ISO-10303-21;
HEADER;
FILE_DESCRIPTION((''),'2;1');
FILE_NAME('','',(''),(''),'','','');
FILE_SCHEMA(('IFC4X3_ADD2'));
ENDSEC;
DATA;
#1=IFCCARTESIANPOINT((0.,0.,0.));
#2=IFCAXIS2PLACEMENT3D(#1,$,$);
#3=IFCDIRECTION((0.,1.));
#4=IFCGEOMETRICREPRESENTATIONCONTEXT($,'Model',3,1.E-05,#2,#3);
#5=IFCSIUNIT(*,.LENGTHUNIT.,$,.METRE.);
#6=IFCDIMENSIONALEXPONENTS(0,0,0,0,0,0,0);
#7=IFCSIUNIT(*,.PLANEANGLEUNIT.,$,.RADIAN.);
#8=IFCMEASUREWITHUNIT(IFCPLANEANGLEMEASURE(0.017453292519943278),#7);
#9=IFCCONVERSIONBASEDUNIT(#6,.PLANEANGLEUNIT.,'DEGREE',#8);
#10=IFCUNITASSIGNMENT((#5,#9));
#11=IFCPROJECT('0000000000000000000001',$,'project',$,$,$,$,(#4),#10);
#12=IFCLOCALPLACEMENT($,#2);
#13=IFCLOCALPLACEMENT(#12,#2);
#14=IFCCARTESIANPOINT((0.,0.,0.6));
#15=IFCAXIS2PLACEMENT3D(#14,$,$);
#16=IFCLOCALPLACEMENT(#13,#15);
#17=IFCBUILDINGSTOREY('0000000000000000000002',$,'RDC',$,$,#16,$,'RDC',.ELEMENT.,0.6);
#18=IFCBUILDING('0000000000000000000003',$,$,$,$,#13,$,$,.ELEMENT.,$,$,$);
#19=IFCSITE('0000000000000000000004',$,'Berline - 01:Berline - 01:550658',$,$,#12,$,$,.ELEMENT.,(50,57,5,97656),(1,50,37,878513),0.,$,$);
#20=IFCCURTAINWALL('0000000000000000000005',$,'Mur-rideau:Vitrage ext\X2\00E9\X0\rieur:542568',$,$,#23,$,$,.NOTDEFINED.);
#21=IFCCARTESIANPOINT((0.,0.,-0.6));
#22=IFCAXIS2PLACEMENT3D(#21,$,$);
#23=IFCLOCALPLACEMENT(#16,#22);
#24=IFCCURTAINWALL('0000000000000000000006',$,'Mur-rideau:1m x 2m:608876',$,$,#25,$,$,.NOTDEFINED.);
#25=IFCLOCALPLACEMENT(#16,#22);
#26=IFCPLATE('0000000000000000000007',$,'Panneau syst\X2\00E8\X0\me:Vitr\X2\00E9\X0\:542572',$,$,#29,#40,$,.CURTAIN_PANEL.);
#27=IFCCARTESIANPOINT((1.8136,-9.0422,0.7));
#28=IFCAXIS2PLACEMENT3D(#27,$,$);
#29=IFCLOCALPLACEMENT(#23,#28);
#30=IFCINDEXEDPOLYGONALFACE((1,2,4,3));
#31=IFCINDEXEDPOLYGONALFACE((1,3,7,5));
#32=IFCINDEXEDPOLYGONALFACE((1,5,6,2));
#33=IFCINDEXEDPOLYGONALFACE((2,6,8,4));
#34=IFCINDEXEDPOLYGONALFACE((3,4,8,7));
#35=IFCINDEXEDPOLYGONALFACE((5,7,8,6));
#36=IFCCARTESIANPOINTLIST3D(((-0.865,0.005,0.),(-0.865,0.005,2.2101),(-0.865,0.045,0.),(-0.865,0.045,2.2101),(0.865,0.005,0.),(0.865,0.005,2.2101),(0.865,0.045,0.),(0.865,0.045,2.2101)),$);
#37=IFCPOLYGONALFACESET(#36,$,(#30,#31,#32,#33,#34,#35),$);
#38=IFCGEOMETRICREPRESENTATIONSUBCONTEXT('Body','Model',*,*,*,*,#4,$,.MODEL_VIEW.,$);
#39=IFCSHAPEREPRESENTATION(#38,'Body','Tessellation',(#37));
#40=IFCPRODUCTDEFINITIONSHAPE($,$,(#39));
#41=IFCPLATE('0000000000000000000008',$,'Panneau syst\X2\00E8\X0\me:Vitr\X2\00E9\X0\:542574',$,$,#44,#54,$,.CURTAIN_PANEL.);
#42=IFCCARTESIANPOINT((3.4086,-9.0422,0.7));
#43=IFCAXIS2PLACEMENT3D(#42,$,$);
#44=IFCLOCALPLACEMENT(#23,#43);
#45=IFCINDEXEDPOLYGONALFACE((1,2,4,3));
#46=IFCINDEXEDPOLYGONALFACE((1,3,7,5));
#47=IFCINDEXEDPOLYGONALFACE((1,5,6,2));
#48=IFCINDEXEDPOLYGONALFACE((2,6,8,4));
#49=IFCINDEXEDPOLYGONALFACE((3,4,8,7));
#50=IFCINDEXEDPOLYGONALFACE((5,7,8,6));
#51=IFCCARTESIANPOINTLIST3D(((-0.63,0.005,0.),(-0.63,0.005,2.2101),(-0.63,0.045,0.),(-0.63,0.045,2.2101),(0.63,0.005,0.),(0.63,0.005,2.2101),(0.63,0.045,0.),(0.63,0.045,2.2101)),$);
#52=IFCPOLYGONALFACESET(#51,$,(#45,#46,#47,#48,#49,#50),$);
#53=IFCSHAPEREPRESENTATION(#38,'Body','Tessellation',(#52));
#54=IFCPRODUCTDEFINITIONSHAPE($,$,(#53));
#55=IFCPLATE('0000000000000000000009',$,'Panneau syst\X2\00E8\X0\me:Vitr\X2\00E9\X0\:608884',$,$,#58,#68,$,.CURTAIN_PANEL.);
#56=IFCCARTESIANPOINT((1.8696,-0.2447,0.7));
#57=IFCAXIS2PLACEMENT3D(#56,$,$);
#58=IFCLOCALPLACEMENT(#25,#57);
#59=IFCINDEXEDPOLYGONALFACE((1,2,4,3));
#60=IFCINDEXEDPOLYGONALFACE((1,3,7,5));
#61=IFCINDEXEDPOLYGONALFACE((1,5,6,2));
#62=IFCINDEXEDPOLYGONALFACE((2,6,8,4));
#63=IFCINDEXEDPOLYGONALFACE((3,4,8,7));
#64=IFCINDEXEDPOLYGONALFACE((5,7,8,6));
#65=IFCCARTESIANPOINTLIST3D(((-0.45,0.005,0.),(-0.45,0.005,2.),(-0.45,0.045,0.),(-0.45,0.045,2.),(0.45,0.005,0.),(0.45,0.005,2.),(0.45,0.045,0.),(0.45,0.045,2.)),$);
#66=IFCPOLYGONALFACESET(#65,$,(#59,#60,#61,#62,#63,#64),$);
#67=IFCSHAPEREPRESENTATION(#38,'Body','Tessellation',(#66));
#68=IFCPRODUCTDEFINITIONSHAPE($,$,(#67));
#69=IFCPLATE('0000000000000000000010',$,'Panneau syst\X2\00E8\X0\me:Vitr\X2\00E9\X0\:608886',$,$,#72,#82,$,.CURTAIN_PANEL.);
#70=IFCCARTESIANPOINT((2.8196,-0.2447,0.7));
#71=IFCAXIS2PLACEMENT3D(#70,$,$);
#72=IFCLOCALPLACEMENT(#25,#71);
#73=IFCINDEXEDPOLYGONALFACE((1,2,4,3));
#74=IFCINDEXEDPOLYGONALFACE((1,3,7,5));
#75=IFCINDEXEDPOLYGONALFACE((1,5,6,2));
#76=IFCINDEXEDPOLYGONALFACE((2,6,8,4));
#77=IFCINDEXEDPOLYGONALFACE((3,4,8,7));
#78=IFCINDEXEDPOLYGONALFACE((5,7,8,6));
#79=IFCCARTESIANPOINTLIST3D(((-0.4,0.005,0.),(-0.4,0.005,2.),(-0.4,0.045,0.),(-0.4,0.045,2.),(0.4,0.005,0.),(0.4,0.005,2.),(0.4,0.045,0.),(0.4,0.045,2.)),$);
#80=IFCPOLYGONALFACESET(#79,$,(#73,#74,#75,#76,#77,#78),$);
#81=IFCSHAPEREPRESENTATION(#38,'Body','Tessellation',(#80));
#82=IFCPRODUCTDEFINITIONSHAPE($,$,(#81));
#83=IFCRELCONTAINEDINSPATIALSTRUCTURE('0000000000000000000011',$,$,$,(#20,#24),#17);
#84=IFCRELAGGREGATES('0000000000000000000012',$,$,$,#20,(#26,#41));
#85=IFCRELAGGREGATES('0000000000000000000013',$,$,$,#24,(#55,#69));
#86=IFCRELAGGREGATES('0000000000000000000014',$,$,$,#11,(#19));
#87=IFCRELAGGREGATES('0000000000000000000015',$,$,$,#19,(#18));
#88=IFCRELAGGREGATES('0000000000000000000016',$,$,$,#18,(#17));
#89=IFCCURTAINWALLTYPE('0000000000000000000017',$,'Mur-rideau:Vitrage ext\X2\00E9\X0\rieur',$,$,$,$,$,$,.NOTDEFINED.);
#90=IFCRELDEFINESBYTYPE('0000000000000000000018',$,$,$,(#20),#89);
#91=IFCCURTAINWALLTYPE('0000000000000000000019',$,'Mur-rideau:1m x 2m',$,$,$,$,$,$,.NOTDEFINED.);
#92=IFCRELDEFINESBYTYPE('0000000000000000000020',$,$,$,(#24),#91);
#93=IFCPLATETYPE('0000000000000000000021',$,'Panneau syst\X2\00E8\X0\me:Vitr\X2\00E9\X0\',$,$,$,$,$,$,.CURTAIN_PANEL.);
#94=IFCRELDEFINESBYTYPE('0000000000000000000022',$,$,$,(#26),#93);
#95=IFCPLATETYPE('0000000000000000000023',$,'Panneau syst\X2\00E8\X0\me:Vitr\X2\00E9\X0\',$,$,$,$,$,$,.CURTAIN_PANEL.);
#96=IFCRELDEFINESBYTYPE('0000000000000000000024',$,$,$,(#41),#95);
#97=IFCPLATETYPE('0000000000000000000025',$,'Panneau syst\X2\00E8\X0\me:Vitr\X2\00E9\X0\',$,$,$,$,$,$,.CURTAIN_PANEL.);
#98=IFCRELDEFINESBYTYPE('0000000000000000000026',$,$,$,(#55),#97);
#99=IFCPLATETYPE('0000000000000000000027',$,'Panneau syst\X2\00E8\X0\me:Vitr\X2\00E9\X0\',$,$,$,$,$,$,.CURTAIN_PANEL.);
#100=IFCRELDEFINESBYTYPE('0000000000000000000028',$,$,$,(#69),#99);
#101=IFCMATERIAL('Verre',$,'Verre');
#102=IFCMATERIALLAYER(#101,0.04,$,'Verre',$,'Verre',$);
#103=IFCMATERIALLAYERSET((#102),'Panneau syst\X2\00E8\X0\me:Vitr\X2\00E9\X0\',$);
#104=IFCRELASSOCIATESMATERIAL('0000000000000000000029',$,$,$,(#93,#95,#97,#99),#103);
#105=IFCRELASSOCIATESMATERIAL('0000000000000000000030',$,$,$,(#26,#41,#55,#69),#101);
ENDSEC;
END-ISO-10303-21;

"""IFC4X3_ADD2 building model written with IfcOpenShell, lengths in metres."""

from ifc_helpers import new_model, entity, si_unit, converted_unit, direction, frame, frame_2d, origin, place, context, subcontext, project, spatial, rectangle, extrude, source, transform, mapped, material, layer, layer_set, type_object, type_shapes, element, aggregate, save


model = new_model("IFC4X3_ADD2")

# Units and contexts
model_context = context("Model", 3, precision=1e-05, world=origin(), true_north=direction((0.0, 1.0)))
body_context = subcontext(model_context, "Body", "Model", "MODEL_VIEW")
ifc_project = project(units=[si_unit("LENGTHUNIT", "METRE"), converted_unit("PLANEANGLEUNIT", "DEGREE", entity("IfcPlaneAngleMeasure", 0.017453292519943278), si_unit("PLANEANGLEUNIT", "RADIAN"), dimensions=[0, 0, 0, 0, 0, 0, 0])], contexts=[model_context])

# Site, building, storey
site_placement = place(None, origin())
site = spatial("IfcSite", under=ifc_project, at=site_placement, Name="Berline - 01:Berline - 01:550658", CompositionType="ELEMENT", RefLatitude=(50, 57, 5, 97656), RefLongitude=(1, 50, 37, 878513), RefElevation=0.0)
building_placement = place(site_placement, origin())
building = spatial("IfcBuilding", under=site, at=building_placement, CompositionType="ELEMENT")
storey_placement = place(building_placement, frame((0.0, 0.0, 0.6)))
storey = spatial("IfcBuildingStorey", under=building, at=storey_placement, Name="RDC", LongName="RDC", CompositionType="ELEMENT", Elevation=0.6)

# Curtain walls
curtain_wall_type_1 = type_object("IfcCurtainWallType", Name="Mur-rideau:Vitrage extérieur", PredefinedType="NOTDEFINED")
curtain_wall_1_placement = place(storey_placement, frame((0.0, 0.0, -0.6)))
curtain_wall_1 = element("IfcCurtainWall", 1, at=curtain_wall_1_placement, inside=storey, type_object=curtain_wall_type_1, Name="Mur-rideau:Vitrage extérieur:542568", PredefinedType="NOTDEFINED")
curtain_wall_type_2 = type_object("IfcCurtainWallType", Name="Mur-rideau:1m x 2m", PredefinedType="NOTDEFINED")
curtain_wall_2_placement = place(storey_placement, frame((0.0, 0.0, -0.6)))
curtain_wall_2 = element("IfcCurtainWall", 2, at=curtain_wall_2_placement, inside=storey, type_object=curtain_wall_type_2, Name="Mur-rideau:1m x 2m:608876", PredefinedType="NOTDEFINED")

# Plates
ifc_material_1 = material(Name="Verre", Category="Verre")
ifc_layer_1 = layer(ifc_material_1, 0.04, Name="Verre", Category="Verre")
ifc_layer_set_1 = layer_set([ifc_layer_1], Name="Panneau système:Vitré")
plate_type_1 = type_object("IfcPlateType", Name="Panneau système:Vitré", PredefinedType="CURTAIN_PANEL", material=ifc_layer_set_1)
shared_shape_1 = source(origin(), body_context, "Body", "SweptSolid", [
    extrude(rectangle(XDim=0.04, YDim=1.73, at=frame_2d((0.0, 0.0), x_axis=(1.0, 0.0))), frame((0.0, 0.025, 0.0), z_axis=(0.0, 0.0, 1.0), x_axis=(0.0, 1.0, 0.0)), (0.0, 0.0, 1.0), 2.2101),
])
type_shapes(plate_type_1, [shared_shape_1])
plate_1_placement = place(curtain_wall_1_placement, frame((1.8136, -9.0422, 0.7)))
plate_1 = element("IfcPlate", 3, at=plate_1_placement, type_object=plate_type_1, material=ifc_material_1, Name="Panneau système:Vitré:542572", PredefinedType="CURTAIN_PANEL", context=body_context, shape_type="MappedRepresentation", body=[
    mapped(shared_shape_1, transform((0.0, 0.0, 0.0), scale=1.0)),
])
plate_type_2 = type_object("IfcPlateType", Name="Panneau système:Vitré", PredefinedType="CURTAIN_PANEL", material=ifc_layer_set_1)
shared_shape_2 = source(origin(), body_context, "Body", "SweptSolid", [
    extrude(rectangle(XDim=0.04, YDim=1.26, at=frame_2d((0.0, 0.0), x_axis=(1.0, 0.0))), frame((0.0, 0.025, 0.0), z_axis=(0.0, 0.0, 1.0), x_axis=(0.0, 1.0, 0.0)), (0.0, 0.0, 1.0), 2.2101),
])
type_shapes(plate_type_2, [shared_shape_2])
plate_2_placement = place(curtain_wall_1_placement, frame((3.4086, -9.0422, 0.7)))
plate_2 = element("IfcPlate", 4, at=plate_2_placement, type_object=plate_type_2, material=ifc_material_1, Name="Panneau système:Vitré:542574", PredefinedType="CURTAIN_PANEL", context=body_context, shape_type="MappedRepresentation", body=[
    mapped(shared_shape_2, transform((0.0, 0.0, 0.0), scale=1.0)),
])
aggregate(curtain_wall_1, [plate_1, plate_2])
plate_type_3 = type_object("IfcPlateType", Name="Panneau système:Vitré", PredefinedType="CURTAIN_PANEL", material=ifc_layer_set_1)
shared_shape_3 = source(origin(), body_context, "Body", "SweptSolid", [
    extrude(rectangle(XDim=0.04, YDim=0.9, at=frame_2d((0.0, 0.0), x_axis=(1.0, 0.0))), frame((0.0, 0.025, 0.0), z_axis=(0.0, 0.0, 1.0), x_axis=(0.0, 1.0, 0.0)), (0.0, 0.0, 1.0), 2.0),
])
type_shapes(plate_type_3, [shared_shape_3])
plate_3_placement = place(curtain_wall_2_placement, frame((1.8696, -0.2447, 0.7)))
plate_3 = element("IfcPlate", 5, at=plate_3_placement, type_object=plate_type_3, material=ifc_material_1, Name="Panneau système:Vitré:608884", PredefinedType="CURTAIN_PANEL", context=body_context, shape_type="MappedRepresentation", body=[
    mapped(shared_shape_3, transform((0.0, 0.0, 0.0), scale=1.0)),
])
plate_type_4 = type_object("IfcPlateType", Name="Panneau système:Vitré", PredefinedType="CURTAIN_PANEL", material=ifc_layer_set_1)
shared_shape_4 = source(origin(), body_context, "Body", "SweptSolid", [
    extrude(rectangle(XDim=0.04, YDim=0.8, at=frame_2d((0.0, 0.0), x_axis=(1.0, 0.0))), frame((0.0, 0.025, 0.0), z_axis=(0.0, 0.0, 1.0), x_axis=(0.0, 1.0, 0.0)), (0.0, 0.0, 1.0), 2.0),
])
type_shapes(plate_type_4, [shared_shape_4])
plate_4_placement = place(curtain_wall_2_placement, frame((2.8196, -0.2447, 0.7)))
plate_4 = element("IfcPlate", 6, at=plate_4_placement, type_object=plate_type_4, material=ifc_material_1, Name="Panneau système:Vitré:608886", PredefinedType="CURTAIN_PANEL", context=body_context, shape_type="MappedRepresentation", body=[
    mapped(shared_shape_4, transform((0.0, 0.0, 0.0), scale=1.0)),
])
aggregate(curtain_wall_2, [plate_3, plate_4])

save(model, "model.ifc")
